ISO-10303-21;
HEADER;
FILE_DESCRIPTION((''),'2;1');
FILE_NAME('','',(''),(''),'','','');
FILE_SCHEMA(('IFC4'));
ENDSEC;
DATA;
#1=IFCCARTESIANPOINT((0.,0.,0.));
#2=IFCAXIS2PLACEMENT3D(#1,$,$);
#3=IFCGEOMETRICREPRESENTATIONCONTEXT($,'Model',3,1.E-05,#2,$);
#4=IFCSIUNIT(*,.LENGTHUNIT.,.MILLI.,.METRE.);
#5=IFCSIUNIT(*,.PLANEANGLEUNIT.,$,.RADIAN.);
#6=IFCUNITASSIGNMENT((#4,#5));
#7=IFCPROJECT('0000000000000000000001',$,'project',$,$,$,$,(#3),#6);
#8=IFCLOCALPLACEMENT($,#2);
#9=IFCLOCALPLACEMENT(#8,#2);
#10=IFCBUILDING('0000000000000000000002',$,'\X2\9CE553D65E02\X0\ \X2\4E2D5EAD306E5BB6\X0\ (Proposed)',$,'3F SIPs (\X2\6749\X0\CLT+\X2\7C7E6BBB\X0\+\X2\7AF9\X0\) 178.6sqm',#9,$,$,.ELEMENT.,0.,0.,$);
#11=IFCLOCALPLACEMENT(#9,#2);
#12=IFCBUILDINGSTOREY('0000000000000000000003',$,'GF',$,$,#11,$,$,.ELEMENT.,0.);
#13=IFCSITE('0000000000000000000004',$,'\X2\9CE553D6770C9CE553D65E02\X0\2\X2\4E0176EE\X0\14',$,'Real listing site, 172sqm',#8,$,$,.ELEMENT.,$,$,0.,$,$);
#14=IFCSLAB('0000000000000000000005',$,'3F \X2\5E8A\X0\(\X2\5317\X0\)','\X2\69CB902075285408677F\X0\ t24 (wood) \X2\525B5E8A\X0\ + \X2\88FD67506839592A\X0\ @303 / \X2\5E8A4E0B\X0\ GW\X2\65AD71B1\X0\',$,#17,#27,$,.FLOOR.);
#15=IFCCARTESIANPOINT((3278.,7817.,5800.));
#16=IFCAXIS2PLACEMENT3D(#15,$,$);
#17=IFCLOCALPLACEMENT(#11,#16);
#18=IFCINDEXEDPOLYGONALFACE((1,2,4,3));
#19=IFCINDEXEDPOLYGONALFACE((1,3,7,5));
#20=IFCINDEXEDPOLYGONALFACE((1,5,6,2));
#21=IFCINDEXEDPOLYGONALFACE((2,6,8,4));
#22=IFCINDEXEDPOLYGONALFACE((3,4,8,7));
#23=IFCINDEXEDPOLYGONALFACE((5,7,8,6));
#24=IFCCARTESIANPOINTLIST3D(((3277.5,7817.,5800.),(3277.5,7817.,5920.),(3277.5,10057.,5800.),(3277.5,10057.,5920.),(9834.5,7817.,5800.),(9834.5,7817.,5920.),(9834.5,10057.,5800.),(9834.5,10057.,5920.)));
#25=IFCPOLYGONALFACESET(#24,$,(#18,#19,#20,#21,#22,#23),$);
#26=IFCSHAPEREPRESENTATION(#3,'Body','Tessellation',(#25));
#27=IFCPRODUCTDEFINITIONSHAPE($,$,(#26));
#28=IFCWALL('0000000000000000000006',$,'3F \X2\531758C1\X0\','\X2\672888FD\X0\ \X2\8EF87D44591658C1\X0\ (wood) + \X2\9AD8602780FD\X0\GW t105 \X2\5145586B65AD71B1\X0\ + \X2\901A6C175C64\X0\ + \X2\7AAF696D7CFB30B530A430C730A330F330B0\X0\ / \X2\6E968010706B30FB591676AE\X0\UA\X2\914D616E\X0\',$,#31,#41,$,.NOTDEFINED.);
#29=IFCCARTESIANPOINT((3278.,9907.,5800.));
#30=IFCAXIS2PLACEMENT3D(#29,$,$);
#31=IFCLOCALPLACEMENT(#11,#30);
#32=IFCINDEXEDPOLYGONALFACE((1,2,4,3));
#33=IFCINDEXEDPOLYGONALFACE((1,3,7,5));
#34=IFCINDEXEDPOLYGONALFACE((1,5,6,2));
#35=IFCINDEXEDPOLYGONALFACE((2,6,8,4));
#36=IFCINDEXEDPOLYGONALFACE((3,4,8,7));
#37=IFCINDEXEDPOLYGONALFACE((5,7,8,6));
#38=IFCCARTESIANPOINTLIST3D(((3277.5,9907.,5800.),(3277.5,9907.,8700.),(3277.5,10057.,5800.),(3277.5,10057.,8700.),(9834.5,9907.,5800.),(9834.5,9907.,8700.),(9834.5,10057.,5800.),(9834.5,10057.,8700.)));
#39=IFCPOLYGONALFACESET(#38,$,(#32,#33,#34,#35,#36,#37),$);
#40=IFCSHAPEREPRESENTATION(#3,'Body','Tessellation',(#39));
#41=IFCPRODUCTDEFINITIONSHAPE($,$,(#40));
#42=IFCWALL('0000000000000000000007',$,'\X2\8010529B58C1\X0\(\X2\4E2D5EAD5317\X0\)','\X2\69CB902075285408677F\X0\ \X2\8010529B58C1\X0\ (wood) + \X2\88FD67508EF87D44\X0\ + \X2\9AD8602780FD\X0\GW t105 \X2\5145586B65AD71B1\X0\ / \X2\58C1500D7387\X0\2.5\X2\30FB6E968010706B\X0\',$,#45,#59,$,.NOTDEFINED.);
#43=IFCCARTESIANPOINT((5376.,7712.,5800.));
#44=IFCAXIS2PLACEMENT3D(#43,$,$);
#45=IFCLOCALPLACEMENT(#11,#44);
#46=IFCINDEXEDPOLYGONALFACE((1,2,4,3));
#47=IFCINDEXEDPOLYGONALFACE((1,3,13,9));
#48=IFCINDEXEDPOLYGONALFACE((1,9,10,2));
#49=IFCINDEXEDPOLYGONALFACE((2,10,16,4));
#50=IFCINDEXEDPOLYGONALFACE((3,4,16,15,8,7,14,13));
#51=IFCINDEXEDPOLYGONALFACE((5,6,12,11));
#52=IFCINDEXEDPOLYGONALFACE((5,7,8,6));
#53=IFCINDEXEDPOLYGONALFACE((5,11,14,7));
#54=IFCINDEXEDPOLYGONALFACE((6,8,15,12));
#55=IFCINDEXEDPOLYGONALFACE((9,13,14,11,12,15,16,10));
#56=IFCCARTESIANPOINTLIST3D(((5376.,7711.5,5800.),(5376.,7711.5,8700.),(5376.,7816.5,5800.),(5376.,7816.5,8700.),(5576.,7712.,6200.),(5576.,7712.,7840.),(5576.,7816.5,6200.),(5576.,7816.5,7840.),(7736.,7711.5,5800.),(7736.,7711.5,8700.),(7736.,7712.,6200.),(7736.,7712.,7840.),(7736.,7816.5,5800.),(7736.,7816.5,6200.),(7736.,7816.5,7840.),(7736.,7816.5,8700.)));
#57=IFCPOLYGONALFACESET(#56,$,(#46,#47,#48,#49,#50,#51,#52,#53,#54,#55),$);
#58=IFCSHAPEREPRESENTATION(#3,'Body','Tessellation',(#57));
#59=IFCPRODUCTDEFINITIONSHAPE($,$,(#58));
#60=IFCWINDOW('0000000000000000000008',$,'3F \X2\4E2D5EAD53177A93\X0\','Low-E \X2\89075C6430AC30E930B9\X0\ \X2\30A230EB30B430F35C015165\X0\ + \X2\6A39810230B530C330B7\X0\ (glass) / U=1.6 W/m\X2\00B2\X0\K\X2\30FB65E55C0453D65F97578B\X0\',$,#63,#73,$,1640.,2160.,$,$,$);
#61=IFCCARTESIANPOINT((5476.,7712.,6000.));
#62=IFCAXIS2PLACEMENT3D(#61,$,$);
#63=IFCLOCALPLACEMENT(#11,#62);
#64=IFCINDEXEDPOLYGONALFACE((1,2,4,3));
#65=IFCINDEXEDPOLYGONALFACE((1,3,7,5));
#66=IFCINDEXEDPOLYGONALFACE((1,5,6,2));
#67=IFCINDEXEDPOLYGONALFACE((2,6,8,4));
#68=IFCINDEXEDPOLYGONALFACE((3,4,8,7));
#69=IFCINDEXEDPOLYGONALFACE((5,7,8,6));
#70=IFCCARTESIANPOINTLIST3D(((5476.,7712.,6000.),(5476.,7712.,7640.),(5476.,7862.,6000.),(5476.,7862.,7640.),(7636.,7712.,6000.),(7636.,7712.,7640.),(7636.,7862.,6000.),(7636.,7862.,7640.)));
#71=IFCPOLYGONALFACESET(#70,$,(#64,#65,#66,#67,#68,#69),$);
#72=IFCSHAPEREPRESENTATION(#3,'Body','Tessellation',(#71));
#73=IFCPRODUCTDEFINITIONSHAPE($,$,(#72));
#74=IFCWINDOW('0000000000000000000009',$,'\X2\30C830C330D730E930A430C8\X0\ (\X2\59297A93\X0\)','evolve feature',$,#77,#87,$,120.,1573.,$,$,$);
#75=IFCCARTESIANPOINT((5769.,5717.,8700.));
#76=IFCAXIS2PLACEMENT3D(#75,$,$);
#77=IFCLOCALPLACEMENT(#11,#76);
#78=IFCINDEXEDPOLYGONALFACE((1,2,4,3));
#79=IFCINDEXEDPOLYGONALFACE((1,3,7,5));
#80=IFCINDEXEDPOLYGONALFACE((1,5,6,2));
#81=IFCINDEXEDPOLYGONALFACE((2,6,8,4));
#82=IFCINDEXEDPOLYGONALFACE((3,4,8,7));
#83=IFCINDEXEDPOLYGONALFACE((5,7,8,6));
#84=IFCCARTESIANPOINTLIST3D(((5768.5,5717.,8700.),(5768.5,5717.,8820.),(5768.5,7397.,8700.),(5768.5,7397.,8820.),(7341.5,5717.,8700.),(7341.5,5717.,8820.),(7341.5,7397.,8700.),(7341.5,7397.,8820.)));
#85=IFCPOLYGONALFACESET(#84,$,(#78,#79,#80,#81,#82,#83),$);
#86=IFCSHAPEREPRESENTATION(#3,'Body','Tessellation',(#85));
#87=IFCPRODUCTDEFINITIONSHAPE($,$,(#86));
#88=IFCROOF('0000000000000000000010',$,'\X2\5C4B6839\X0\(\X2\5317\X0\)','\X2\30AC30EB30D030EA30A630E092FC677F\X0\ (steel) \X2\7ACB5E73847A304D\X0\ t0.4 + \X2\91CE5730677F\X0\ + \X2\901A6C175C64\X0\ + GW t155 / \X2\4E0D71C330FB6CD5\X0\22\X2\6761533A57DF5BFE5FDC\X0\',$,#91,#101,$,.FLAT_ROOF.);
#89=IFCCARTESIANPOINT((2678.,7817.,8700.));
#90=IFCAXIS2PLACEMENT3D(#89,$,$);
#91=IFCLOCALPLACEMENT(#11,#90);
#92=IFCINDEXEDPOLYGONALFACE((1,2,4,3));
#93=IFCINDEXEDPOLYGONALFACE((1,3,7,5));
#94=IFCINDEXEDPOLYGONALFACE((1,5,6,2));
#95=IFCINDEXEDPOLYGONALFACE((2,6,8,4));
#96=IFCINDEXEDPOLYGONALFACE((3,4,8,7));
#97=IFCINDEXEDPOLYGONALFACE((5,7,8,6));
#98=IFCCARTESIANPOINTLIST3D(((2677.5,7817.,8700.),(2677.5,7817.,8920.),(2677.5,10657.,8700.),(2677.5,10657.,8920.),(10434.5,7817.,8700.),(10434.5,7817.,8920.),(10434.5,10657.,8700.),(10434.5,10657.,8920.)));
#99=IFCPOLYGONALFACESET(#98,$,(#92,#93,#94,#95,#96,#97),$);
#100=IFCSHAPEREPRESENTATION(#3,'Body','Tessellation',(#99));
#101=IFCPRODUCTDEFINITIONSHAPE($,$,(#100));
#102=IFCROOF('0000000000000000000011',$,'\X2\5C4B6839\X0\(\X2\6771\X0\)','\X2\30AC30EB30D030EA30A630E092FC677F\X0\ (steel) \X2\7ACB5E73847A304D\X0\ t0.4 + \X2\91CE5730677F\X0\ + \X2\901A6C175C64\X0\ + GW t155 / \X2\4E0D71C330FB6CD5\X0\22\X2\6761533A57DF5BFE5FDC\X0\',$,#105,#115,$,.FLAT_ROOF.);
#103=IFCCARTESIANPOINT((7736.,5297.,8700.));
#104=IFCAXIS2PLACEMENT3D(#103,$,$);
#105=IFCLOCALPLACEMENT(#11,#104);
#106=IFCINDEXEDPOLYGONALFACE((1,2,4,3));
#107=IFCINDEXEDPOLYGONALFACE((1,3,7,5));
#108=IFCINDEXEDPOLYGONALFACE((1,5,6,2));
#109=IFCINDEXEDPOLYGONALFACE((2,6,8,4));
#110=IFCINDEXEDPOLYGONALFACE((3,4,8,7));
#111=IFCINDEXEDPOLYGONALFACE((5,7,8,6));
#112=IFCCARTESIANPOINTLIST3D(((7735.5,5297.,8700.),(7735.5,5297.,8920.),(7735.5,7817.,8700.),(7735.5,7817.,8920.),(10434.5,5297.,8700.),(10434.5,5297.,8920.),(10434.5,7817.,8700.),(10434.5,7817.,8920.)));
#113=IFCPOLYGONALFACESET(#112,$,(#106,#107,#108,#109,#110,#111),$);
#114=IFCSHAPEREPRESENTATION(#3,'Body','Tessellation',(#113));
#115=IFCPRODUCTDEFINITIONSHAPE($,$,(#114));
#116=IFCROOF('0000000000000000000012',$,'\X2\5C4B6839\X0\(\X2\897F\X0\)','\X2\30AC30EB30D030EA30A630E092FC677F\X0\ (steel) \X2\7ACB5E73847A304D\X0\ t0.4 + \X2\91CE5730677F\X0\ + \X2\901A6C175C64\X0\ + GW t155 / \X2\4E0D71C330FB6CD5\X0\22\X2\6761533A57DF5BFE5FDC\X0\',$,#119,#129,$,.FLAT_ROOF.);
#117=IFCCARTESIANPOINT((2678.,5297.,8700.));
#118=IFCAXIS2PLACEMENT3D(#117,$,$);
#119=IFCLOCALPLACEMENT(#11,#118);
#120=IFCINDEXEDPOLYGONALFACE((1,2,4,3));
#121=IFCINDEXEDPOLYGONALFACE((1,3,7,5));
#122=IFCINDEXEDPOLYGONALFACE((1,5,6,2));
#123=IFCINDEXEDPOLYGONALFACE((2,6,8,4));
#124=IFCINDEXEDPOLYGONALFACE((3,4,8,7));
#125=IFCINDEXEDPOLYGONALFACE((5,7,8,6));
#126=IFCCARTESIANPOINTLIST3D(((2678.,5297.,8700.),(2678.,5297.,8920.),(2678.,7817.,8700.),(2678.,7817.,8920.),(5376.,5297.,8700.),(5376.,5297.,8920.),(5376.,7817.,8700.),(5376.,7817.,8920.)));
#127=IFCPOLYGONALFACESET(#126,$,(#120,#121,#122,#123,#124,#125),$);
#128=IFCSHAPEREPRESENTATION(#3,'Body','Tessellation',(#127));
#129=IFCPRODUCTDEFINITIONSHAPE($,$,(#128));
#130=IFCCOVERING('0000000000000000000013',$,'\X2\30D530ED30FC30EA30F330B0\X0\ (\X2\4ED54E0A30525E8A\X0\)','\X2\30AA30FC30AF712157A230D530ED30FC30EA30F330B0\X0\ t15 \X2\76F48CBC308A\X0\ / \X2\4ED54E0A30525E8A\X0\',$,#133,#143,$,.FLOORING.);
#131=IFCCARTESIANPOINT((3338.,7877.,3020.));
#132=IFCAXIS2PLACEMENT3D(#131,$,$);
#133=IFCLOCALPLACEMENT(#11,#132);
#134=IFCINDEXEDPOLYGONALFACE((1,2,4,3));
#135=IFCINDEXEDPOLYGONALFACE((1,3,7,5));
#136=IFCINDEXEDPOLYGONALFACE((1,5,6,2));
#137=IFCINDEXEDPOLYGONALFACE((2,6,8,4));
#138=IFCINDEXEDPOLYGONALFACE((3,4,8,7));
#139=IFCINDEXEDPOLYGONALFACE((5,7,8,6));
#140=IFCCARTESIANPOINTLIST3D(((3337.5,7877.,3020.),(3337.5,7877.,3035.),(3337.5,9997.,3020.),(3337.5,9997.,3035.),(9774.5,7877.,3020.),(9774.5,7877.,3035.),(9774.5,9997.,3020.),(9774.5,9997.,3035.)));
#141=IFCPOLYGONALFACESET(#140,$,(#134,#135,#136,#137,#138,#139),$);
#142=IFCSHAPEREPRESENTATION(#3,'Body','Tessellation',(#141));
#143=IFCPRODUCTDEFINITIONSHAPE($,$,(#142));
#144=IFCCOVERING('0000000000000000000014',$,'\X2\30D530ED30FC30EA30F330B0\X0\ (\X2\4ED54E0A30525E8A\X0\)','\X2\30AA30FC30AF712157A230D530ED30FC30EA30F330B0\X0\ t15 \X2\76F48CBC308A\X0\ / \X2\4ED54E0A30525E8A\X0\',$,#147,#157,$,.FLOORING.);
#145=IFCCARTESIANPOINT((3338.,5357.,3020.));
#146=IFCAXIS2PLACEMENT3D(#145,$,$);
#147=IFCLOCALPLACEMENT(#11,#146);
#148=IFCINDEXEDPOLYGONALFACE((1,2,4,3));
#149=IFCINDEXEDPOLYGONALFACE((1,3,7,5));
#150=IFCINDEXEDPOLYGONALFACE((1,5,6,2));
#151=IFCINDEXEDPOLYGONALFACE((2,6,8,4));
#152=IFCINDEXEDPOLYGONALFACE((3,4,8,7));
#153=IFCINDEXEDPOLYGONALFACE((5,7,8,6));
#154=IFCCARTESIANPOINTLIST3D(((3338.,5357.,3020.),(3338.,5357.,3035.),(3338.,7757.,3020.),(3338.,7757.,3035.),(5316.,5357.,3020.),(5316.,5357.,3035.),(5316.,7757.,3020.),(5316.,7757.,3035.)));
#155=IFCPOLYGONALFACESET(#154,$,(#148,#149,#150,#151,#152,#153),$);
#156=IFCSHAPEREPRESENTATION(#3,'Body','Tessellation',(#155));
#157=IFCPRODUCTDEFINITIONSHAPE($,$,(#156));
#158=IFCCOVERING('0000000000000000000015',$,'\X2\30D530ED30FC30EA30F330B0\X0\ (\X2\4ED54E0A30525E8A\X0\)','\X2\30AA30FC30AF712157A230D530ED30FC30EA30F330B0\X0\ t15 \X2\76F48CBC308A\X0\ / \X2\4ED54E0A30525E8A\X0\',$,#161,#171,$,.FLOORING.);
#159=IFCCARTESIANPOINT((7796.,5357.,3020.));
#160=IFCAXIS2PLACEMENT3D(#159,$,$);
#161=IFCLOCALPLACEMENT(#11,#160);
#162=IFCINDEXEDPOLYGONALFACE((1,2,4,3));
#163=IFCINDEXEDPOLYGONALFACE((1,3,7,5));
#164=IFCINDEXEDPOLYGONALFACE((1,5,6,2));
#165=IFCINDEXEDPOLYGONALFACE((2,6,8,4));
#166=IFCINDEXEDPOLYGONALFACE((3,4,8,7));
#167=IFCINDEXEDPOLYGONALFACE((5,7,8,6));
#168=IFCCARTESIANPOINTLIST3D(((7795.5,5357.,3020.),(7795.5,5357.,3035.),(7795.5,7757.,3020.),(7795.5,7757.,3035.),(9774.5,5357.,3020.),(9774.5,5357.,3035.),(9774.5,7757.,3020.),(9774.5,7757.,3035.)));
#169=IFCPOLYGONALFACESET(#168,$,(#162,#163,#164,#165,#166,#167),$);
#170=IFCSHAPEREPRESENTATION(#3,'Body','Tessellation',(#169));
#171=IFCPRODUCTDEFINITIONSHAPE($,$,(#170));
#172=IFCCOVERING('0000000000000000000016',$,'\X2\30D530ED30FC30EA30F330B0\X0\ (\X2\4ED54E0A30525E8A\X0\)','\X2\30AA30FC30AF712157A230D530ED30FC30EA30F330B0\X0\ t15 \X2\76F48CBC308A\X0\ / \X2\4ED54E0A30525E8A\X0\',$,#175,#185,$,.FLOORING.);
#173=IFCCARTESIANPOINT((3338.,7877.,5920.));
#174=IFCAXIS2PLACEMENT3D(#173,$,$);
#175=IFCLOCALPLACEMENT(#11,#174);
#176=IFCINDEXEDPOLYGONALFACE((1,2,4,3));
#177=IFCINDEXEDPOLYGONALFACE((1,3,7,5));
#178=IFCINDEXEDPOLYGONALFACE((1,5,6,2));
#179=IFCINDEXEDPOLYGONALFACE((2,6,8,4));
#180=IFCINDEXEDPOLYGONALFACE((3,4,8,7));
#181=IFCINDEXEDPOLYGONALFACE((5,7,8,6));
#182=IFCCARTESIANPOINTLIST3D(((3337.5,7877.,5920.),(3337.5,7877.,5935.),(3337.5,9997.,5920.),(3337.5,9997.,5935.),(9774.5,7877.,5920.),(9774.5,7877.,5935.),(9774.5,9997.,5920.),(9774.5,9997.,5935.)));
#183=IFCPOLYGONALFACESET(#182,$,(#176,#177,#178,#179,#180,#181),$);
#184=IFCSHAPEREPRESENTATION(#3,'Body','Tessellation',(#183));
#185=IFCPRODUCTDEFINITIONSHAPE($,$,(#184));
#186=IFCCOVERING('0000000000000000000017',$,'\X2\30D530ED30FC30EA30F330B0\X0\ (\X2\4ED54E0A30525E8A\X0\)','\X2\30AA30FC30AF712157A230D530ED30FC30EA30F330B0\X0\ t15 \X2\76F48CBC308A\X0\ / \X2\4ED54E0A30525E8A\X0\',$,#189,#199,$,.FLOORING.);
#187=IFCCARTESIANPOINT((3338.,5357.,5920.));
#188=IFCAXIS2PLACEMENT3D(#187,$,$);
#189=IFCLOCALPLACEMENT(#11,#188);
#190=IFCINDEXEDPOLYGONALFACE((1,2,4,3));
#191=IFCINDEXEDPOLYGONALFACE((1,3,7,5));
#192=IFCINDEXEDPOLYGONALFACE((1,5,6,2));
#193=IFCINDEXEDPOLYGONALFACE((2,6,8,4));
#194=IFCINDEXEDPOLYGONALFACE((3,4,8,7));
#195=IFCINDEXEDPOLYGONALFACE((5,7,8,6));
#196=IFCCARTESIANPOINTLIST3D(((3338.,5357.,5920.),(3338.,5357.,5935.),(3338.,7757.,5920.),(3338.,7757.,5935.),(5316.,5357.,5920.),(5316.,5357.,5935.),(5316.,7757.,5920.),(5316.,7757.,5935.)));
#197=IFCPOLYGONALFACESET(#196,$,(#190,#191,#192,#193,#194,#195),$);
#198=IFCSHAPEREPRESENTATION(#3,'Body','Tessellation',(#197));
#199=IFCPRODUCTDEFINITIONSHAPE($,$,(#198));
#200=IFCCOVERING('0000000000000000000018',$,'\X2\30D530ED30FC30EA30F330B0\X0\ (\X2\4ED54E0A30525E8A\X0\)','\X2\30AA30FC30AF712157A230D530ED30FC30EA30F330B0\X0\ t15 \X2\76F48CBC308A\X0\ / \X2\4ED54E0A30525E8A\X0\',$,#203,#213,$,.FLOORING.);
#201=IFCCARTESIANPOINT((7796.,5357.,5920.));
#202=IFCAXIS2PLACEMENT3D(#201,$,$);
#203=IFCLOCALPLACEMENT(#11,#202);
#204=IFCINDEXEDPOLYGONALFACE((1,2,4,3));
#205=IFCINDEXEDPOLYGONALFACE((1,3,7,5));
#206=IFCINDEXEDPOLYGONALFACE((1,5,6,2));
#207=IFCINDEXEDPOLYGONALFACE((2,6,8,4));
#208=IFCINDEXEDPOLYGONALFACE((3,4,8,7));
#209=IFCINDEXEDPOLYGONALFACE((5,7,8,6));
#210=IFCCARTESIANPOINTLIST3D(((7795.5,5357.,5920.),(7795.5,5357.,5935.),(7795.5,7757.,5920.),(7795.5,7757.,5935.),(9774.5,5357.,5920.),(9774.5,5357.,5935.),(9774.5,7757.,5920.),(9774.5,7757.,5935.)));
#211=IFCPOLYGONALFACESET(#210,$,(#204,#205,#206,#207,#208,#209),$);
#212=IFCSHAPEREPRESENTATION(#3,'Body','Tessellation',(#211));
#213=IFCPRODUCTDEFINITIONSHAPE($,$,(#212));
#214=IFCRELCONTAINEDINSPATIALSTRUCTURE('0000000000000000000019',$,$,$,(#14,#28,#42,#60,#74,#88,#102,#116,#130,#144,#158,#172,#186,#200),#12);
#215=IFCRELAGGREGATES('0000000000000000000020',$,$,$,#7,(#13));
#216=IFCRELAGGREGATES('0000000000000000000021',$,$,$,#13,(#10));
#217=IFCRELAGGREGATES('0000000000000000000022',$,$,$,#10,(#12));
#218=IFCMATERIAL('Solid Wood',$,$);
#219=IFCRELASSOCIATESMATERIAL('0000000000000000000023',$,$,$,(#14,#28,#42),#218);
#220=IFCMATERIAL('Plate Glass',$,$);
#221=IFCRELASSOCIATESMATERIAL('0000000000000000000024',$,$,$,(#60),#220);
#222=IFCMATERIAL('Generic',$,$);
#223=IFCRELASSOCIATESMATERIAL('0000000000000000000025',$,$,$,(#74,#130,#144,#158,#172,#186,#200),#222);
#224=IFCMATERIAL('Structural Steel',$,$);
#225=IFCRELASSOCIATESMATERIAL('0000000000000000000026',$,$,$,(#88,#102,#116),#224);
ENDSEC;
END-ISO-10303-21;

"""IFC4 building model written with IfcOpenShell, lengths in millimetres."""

from ifc_helpers import new_model, si_unit, frame, frame_2d, origin, place, context, project, spatial, rectangle, extrude, material, element, fill, save


model = new_model("IFC4")

# Units and contexts
model_context = context("Model", 3, precision=1e-05, world=origin())
ifc_project = project(units=[si_unit("LENGTHUNIT", "METRE", prefix="MILLI"), si_unit("PLANEANGLEUNIT", "RADIAN")], contexts=[model_context])

# Site, building, storey
site_placement = place(None, origin())
site = spatial("IfcSite", under=ifc_project, at=site_placement, Name="鳥取県鳥取市2丁目14", ObjectType="Real listing site, 172sqm", CompositionType="ELEMENT", RefElevation=0.0)
building_placement = place(site_placement, origin())
building = spatial("IfcBuilding", under=site, at=building_placement, Name="鳥取市 中庭の家 (Proposed)", ObjectType="3F SIPs (杉CLT+籾殻+竹) 178.6sqm", CompositionType="ELEMENT", ElevationOfRefHeight=0.0, ElevationOfTerrain=0.0)
storey_placement = place(building_placement, origin())
storey = spatial("IfcBuildingStorey", under=building, at=storey_placement, Name="GF", CompositionType="ELEMENT", Elevation=0.0)

# Slab
ifc_material_1 = material(Name="Solid Wood")
slab_placement = place(storey_placement, frame((3278.0, 7817.0, 5800.0)))
element("IfcSlab", 1, at=slab_placement, inside=storey, material=ifc_material_1, Name="3F 床(北)", Description="構造用合板 t24 (wood) 剛床 + 製材根太 @303 / 床下 GW断熱", PredefinedType="FLOOR", context=model_context, shape_type="SweptSolid", body=[
    extrude(rectangle(XDim=6557.0, YDim=2240.0, at=frame_2d((3278.0, 1120.0))), frame((3278.0, 7817.0, 5800.0)), (0.0, 0.0, 1.0), 120.0),
])

# Wall
wall_1_placement = place(storey_placement, frame((3278.0, 9907.0, 5800.0)))
element("IfcWall", 2, at=wall_1_placement, inside=storey, material=ifc_material_1, Name="3F 北壁", Description="木製 軸組外壁 (wood) + 高性能GW t105 充填断熱 + 通気層 + 窯業系サイディング / 準耐火・外皮UA配慮", PredefinedType="NOTDEFINED", context=model_context, shape_type="SweptSolid", body=[
    extrude(rectangle(XDim=6557.0, YDim=150.0, at=frame_2d((3278.0, 75.0))), frame((3278.0, 9907.0, 5800.0)), (0.0, 0.0, 1.0), 2900.0),
])

# Wall, opening, window
wall_2_placement = place(storey_placement, frame((5376.0, 7712.0, 5800.0)))
wall_2 = element("IfcWall", 3, at=wall_2_placement, inside=storey, material=ifc_material_1, Name="耐力壁(中庭北)", Description="構造用合板 耐力壁 (wood) + 製材軸組 + 高性能GW t105 充填断熱 / 壁倍率2.5・準耐火", PredefinedType="NOTDEFINED", context=model_context, shape_type="SweptSolid", body=[
    extrude(rectangle(XDim=2360.0, YDim=105.0, at=frame_2d((1180.0, 52.0))), frame((5376.0, 7712.0, 5800.0)), (0.0, 0.0, 1.0), 2900.0),
])
opening_placement = place(storey_placement, frame((5476.0, 7712.0, 6000.0)))
opening = element("IfcOpeningElement", 4, at=opening_placement, cuts=wall_2, PredefinedType="NOTDEFINED", context=model_context, shape_type="SweptSolid", body=[
    extrude(rectangle(XDim=2160.0, YDim=150.0, at=frame_2d((1080.0, 75.0))), frame((5476.0, 7712.0, 6000.0)), (0.0, 0.0, 1.0), 1640.0),
])
ifc_material_2 = material(Name="Plate Glass")
window_1_placement = place(storey_placement, frame((5476.0, 7712.0, 6000.0)))
window_1 = element("IfcWindow", 5, at=window_1_placement, inside=storey, material=ifc_material_2, Name="3F 中庭北窓", Description="Low-E 複層ガラス アルゴン封入 + 樹脂サッシ (glass) / U=1.6 W/m²K・日射取得型", OverallHeight=1640.0, OverallWidth=2160.0, context=model_context, shape_type="SweptSolid", body=[
    extrude(rectangle(XDim=2160.0, YDim=150.0, at=frame_2d((1080.0, 75.0))), frame((5476.0, 7712.0, 6000.0)), (0.0, 0.0, 1.0), 1640.0),
])
fill(opening, window_1)

# Window
ifc_material_3 = material(Name="Generic")
window_2_placement = place(storey_placement, frame((5769.0, 5717.0, 8700.0)))
element("IfcWindow", 6, at=window_2_placement, inside=storey, material=ifc_material_3, Name="トップライト (天窓)", Description="evolve feature", OverallHeight=120.0, OverallWidth=1573.0, context=model_context, shape_type="SweptSolid", body=[
    extrude(rectangle(XDim=1573.0, YDim=1680.0, at=frame_2d((786.0, 840.0))), frame((5769.0, 5717.0, 8700.0)), (0.0, 0.0, 1.0), 120.0),
])

# Roofs
ifc_material_4 = material(Name="Structural Steel")
roof_1_placement = place(storey_placement, frame((2678.0, 7817.0, 8700.0)))
element("IfcRoof", 7, at=roof_1_placement, inside=storey, material=ifc_material_4, Name="屋根(北)", Description="ガルバリウム鋼板 (steel) 立平葺き t0.4 + 野地板 + 通気層 + GW t155 / 不燃・法22条区域対応", PredefinedType="FLAT_ROOF", context=model_context, shape_type="SweptSolid", body=[
    extrude(rectangle(XDim=7757.0, YDim=2840.0, at=frame_2d((3878.0, 1420.0))), frame((2678.0, 7817.0, 8700.0)), (0.0, 0.0, 1.0), 220.0),
])
roof_2_placement = place(storey_placement, frame((7736.0, 5297.0, 8700.0)))
element("IfcRoof", 8, at=roof_2_placement, inside=storey, material=ifc_material_4, Name="屋根(東)", Description="ガルバリウム鋼板 (steel) 立平葺き t0.4 + 野地板 + 通気層 + GW t155 / 不燃・法22条区域対応", PredefinedType="FLAT_ROOF", context=model_context, shape_type="SweptSolid", body=[
    extrude(rectangle(XDim=2699.0, YDim=2520.0, at=frame_2d((1349.0, 1260.0))), frame((7736.0, 5297.0, 8700.0)), (0.0, 0.0, 1.0), 220.0),
])
roof_3_placement = place(storey_placement, frame((2678.0, 5297.0, 8700.0)))
element("IfcRoof", 9, at=roof_3_placement, inside=storey, material=ifc_material_4, Name="屋根(西)", Description="ガルバリウム鋼板 (steel) 立平葺き t0.4 + 野地板 + 通気層 + GW t155 / 不燃・法22条区域対応", PredefinedType="FLAT_ROOF", context=model_context, shape_type="SweptSolid", body=[
    extrude(rectangle(XDim=2698.0, YDim=2520.0, at=frame_2d((1349.0, 1260.0))), frame((2678.0, 5297.0, 8700.0)), (0.0, 0.0, 1.0), 220.0),
])

# Coverings
covering_1_placement = place(storey_placement, frame((3338.0, 7877.0, 3020.0)))
element("IfcCovering", 10, at=covering_1_placement, inside=storey, material=ifc_material_3, Name="フローリング (仕上げ床)", Description="オーク無垢フローリング t15 直貼り / 仕上げ床", PredefinedType="FLOORING", context=model_context, shape_type="SweptSolid", body=[
    extrude(rectangle(XDim=6437.0, YDim=2120.0, at=frame_2d((3218.0, 1060.0))), frame((3338.0, 7877.0, 3020.0)), (0.0, 0.0, 1.0), 15.0),
])
covering_2_placement = place(storey_placement, frame((3338.0, 5357.0, 3020.0)))
element("IfcCovering", 11, at=covering_2_placement, inside=storey, material=ifc_material_3, Name="フローリング (仕上げ床)", Description="オーク無垢フローリング t15 直貼り / 仕上げ床", PredefinedType="FLOORING", context=model_context, shape_type="SweptSolid", body=[
    extrude(rectangle(XDim=1978.0, YDim=2400.0, at=frame_2d((989.0, 1200.0))), frame((3338.0, 5357.0, 3020.0)), (0.0, 0.0, 1.0), 15.0),
])
covering_3_placement = place(storey_placement, frame((7796.0, 5357.0, 3020.0)))
element("IfcCovering", 12, at=covering_3_placement, inside=storey, material=ifc_material_3, Name="フローリング (仕上げ床)", Description="オーク無垢フローリング t15 直貼り / 仕上げ床", PredefinedType="FLOORING", context=model_context, shape_type="SweptSolid", body=[
    extrude(rectangle(XDim=1979.0, YDim=2400.0, at=frame_2d((989.0, 1200.0))), frame((7796.0, 5357.0, 3020.0)), (0.0, 0.0, 1.0), 15.0),
])
covering_4_placement = place(storey_placement, frame((3338.0, 7877.0, 5920.0)))
element("IfcCovering", 13, at=covering_4_placement, inside=storey, material=ifc_material_3, Name="フローリング (仕上げ床)", Description="オーク無垢フローリング t15 直貼り / 仕上げ床", PredefinedType="FLOORING", context=model_context, shape_type="SweptSolid", body=[
    extrude(rectangle(XDim=6437.0, YDim=2120.0, at=frame_2d((3218.0, 1060.0))), frame((3338.0, 7877.0, 5920.0)), (0.0, 0.0, 1.0), 15.0),
])
covering_5_placement = place(storey_placement, frame((3338.0, 5357.0, 5920.0)))
element("IfcCovering", 14, at=covering_5_placement, inside=storey, material=ifc_material_3, Name="フローリング (仕上げ床)", Description="オーク無垢フローリング t15 直貼り / 仕上げ床", PredefinedType="FLOORING", context=model_context, shape_type="SweptSolid", body=[
    extrude(rectangle(XDim=1978.0, YDim=2400.0, at=frame_2d((989.0, 1200.0))), frame((3338.0, 5357.0, 5920.0)), (0.0, 0.0, 1.0), 15.0),
])
covering_6_placement = place(storey_placement, frame((7796.0, 5357.0, 5920.0)))
element("IfcCovering", 15, at=covering_6_placement, inside=storey, material=ifc_material_3, Name="フローリング (仕上げ床)", Description="オーク無垢フローリング t15 直貼り / 仕上げ床", PredefinedType="FLOORING", context=model_context, shape_type="SweptSolid", body=[
    extrude(rectangle(XDim=1979.0, YDim=2400.0, at=frame_2d((989.0, 1200.0))), frame((7796.0, 5357.0, 5920.0)), (0.0, 0.0, 1.0), 15.0),
])

save(model, "model.ifc")
